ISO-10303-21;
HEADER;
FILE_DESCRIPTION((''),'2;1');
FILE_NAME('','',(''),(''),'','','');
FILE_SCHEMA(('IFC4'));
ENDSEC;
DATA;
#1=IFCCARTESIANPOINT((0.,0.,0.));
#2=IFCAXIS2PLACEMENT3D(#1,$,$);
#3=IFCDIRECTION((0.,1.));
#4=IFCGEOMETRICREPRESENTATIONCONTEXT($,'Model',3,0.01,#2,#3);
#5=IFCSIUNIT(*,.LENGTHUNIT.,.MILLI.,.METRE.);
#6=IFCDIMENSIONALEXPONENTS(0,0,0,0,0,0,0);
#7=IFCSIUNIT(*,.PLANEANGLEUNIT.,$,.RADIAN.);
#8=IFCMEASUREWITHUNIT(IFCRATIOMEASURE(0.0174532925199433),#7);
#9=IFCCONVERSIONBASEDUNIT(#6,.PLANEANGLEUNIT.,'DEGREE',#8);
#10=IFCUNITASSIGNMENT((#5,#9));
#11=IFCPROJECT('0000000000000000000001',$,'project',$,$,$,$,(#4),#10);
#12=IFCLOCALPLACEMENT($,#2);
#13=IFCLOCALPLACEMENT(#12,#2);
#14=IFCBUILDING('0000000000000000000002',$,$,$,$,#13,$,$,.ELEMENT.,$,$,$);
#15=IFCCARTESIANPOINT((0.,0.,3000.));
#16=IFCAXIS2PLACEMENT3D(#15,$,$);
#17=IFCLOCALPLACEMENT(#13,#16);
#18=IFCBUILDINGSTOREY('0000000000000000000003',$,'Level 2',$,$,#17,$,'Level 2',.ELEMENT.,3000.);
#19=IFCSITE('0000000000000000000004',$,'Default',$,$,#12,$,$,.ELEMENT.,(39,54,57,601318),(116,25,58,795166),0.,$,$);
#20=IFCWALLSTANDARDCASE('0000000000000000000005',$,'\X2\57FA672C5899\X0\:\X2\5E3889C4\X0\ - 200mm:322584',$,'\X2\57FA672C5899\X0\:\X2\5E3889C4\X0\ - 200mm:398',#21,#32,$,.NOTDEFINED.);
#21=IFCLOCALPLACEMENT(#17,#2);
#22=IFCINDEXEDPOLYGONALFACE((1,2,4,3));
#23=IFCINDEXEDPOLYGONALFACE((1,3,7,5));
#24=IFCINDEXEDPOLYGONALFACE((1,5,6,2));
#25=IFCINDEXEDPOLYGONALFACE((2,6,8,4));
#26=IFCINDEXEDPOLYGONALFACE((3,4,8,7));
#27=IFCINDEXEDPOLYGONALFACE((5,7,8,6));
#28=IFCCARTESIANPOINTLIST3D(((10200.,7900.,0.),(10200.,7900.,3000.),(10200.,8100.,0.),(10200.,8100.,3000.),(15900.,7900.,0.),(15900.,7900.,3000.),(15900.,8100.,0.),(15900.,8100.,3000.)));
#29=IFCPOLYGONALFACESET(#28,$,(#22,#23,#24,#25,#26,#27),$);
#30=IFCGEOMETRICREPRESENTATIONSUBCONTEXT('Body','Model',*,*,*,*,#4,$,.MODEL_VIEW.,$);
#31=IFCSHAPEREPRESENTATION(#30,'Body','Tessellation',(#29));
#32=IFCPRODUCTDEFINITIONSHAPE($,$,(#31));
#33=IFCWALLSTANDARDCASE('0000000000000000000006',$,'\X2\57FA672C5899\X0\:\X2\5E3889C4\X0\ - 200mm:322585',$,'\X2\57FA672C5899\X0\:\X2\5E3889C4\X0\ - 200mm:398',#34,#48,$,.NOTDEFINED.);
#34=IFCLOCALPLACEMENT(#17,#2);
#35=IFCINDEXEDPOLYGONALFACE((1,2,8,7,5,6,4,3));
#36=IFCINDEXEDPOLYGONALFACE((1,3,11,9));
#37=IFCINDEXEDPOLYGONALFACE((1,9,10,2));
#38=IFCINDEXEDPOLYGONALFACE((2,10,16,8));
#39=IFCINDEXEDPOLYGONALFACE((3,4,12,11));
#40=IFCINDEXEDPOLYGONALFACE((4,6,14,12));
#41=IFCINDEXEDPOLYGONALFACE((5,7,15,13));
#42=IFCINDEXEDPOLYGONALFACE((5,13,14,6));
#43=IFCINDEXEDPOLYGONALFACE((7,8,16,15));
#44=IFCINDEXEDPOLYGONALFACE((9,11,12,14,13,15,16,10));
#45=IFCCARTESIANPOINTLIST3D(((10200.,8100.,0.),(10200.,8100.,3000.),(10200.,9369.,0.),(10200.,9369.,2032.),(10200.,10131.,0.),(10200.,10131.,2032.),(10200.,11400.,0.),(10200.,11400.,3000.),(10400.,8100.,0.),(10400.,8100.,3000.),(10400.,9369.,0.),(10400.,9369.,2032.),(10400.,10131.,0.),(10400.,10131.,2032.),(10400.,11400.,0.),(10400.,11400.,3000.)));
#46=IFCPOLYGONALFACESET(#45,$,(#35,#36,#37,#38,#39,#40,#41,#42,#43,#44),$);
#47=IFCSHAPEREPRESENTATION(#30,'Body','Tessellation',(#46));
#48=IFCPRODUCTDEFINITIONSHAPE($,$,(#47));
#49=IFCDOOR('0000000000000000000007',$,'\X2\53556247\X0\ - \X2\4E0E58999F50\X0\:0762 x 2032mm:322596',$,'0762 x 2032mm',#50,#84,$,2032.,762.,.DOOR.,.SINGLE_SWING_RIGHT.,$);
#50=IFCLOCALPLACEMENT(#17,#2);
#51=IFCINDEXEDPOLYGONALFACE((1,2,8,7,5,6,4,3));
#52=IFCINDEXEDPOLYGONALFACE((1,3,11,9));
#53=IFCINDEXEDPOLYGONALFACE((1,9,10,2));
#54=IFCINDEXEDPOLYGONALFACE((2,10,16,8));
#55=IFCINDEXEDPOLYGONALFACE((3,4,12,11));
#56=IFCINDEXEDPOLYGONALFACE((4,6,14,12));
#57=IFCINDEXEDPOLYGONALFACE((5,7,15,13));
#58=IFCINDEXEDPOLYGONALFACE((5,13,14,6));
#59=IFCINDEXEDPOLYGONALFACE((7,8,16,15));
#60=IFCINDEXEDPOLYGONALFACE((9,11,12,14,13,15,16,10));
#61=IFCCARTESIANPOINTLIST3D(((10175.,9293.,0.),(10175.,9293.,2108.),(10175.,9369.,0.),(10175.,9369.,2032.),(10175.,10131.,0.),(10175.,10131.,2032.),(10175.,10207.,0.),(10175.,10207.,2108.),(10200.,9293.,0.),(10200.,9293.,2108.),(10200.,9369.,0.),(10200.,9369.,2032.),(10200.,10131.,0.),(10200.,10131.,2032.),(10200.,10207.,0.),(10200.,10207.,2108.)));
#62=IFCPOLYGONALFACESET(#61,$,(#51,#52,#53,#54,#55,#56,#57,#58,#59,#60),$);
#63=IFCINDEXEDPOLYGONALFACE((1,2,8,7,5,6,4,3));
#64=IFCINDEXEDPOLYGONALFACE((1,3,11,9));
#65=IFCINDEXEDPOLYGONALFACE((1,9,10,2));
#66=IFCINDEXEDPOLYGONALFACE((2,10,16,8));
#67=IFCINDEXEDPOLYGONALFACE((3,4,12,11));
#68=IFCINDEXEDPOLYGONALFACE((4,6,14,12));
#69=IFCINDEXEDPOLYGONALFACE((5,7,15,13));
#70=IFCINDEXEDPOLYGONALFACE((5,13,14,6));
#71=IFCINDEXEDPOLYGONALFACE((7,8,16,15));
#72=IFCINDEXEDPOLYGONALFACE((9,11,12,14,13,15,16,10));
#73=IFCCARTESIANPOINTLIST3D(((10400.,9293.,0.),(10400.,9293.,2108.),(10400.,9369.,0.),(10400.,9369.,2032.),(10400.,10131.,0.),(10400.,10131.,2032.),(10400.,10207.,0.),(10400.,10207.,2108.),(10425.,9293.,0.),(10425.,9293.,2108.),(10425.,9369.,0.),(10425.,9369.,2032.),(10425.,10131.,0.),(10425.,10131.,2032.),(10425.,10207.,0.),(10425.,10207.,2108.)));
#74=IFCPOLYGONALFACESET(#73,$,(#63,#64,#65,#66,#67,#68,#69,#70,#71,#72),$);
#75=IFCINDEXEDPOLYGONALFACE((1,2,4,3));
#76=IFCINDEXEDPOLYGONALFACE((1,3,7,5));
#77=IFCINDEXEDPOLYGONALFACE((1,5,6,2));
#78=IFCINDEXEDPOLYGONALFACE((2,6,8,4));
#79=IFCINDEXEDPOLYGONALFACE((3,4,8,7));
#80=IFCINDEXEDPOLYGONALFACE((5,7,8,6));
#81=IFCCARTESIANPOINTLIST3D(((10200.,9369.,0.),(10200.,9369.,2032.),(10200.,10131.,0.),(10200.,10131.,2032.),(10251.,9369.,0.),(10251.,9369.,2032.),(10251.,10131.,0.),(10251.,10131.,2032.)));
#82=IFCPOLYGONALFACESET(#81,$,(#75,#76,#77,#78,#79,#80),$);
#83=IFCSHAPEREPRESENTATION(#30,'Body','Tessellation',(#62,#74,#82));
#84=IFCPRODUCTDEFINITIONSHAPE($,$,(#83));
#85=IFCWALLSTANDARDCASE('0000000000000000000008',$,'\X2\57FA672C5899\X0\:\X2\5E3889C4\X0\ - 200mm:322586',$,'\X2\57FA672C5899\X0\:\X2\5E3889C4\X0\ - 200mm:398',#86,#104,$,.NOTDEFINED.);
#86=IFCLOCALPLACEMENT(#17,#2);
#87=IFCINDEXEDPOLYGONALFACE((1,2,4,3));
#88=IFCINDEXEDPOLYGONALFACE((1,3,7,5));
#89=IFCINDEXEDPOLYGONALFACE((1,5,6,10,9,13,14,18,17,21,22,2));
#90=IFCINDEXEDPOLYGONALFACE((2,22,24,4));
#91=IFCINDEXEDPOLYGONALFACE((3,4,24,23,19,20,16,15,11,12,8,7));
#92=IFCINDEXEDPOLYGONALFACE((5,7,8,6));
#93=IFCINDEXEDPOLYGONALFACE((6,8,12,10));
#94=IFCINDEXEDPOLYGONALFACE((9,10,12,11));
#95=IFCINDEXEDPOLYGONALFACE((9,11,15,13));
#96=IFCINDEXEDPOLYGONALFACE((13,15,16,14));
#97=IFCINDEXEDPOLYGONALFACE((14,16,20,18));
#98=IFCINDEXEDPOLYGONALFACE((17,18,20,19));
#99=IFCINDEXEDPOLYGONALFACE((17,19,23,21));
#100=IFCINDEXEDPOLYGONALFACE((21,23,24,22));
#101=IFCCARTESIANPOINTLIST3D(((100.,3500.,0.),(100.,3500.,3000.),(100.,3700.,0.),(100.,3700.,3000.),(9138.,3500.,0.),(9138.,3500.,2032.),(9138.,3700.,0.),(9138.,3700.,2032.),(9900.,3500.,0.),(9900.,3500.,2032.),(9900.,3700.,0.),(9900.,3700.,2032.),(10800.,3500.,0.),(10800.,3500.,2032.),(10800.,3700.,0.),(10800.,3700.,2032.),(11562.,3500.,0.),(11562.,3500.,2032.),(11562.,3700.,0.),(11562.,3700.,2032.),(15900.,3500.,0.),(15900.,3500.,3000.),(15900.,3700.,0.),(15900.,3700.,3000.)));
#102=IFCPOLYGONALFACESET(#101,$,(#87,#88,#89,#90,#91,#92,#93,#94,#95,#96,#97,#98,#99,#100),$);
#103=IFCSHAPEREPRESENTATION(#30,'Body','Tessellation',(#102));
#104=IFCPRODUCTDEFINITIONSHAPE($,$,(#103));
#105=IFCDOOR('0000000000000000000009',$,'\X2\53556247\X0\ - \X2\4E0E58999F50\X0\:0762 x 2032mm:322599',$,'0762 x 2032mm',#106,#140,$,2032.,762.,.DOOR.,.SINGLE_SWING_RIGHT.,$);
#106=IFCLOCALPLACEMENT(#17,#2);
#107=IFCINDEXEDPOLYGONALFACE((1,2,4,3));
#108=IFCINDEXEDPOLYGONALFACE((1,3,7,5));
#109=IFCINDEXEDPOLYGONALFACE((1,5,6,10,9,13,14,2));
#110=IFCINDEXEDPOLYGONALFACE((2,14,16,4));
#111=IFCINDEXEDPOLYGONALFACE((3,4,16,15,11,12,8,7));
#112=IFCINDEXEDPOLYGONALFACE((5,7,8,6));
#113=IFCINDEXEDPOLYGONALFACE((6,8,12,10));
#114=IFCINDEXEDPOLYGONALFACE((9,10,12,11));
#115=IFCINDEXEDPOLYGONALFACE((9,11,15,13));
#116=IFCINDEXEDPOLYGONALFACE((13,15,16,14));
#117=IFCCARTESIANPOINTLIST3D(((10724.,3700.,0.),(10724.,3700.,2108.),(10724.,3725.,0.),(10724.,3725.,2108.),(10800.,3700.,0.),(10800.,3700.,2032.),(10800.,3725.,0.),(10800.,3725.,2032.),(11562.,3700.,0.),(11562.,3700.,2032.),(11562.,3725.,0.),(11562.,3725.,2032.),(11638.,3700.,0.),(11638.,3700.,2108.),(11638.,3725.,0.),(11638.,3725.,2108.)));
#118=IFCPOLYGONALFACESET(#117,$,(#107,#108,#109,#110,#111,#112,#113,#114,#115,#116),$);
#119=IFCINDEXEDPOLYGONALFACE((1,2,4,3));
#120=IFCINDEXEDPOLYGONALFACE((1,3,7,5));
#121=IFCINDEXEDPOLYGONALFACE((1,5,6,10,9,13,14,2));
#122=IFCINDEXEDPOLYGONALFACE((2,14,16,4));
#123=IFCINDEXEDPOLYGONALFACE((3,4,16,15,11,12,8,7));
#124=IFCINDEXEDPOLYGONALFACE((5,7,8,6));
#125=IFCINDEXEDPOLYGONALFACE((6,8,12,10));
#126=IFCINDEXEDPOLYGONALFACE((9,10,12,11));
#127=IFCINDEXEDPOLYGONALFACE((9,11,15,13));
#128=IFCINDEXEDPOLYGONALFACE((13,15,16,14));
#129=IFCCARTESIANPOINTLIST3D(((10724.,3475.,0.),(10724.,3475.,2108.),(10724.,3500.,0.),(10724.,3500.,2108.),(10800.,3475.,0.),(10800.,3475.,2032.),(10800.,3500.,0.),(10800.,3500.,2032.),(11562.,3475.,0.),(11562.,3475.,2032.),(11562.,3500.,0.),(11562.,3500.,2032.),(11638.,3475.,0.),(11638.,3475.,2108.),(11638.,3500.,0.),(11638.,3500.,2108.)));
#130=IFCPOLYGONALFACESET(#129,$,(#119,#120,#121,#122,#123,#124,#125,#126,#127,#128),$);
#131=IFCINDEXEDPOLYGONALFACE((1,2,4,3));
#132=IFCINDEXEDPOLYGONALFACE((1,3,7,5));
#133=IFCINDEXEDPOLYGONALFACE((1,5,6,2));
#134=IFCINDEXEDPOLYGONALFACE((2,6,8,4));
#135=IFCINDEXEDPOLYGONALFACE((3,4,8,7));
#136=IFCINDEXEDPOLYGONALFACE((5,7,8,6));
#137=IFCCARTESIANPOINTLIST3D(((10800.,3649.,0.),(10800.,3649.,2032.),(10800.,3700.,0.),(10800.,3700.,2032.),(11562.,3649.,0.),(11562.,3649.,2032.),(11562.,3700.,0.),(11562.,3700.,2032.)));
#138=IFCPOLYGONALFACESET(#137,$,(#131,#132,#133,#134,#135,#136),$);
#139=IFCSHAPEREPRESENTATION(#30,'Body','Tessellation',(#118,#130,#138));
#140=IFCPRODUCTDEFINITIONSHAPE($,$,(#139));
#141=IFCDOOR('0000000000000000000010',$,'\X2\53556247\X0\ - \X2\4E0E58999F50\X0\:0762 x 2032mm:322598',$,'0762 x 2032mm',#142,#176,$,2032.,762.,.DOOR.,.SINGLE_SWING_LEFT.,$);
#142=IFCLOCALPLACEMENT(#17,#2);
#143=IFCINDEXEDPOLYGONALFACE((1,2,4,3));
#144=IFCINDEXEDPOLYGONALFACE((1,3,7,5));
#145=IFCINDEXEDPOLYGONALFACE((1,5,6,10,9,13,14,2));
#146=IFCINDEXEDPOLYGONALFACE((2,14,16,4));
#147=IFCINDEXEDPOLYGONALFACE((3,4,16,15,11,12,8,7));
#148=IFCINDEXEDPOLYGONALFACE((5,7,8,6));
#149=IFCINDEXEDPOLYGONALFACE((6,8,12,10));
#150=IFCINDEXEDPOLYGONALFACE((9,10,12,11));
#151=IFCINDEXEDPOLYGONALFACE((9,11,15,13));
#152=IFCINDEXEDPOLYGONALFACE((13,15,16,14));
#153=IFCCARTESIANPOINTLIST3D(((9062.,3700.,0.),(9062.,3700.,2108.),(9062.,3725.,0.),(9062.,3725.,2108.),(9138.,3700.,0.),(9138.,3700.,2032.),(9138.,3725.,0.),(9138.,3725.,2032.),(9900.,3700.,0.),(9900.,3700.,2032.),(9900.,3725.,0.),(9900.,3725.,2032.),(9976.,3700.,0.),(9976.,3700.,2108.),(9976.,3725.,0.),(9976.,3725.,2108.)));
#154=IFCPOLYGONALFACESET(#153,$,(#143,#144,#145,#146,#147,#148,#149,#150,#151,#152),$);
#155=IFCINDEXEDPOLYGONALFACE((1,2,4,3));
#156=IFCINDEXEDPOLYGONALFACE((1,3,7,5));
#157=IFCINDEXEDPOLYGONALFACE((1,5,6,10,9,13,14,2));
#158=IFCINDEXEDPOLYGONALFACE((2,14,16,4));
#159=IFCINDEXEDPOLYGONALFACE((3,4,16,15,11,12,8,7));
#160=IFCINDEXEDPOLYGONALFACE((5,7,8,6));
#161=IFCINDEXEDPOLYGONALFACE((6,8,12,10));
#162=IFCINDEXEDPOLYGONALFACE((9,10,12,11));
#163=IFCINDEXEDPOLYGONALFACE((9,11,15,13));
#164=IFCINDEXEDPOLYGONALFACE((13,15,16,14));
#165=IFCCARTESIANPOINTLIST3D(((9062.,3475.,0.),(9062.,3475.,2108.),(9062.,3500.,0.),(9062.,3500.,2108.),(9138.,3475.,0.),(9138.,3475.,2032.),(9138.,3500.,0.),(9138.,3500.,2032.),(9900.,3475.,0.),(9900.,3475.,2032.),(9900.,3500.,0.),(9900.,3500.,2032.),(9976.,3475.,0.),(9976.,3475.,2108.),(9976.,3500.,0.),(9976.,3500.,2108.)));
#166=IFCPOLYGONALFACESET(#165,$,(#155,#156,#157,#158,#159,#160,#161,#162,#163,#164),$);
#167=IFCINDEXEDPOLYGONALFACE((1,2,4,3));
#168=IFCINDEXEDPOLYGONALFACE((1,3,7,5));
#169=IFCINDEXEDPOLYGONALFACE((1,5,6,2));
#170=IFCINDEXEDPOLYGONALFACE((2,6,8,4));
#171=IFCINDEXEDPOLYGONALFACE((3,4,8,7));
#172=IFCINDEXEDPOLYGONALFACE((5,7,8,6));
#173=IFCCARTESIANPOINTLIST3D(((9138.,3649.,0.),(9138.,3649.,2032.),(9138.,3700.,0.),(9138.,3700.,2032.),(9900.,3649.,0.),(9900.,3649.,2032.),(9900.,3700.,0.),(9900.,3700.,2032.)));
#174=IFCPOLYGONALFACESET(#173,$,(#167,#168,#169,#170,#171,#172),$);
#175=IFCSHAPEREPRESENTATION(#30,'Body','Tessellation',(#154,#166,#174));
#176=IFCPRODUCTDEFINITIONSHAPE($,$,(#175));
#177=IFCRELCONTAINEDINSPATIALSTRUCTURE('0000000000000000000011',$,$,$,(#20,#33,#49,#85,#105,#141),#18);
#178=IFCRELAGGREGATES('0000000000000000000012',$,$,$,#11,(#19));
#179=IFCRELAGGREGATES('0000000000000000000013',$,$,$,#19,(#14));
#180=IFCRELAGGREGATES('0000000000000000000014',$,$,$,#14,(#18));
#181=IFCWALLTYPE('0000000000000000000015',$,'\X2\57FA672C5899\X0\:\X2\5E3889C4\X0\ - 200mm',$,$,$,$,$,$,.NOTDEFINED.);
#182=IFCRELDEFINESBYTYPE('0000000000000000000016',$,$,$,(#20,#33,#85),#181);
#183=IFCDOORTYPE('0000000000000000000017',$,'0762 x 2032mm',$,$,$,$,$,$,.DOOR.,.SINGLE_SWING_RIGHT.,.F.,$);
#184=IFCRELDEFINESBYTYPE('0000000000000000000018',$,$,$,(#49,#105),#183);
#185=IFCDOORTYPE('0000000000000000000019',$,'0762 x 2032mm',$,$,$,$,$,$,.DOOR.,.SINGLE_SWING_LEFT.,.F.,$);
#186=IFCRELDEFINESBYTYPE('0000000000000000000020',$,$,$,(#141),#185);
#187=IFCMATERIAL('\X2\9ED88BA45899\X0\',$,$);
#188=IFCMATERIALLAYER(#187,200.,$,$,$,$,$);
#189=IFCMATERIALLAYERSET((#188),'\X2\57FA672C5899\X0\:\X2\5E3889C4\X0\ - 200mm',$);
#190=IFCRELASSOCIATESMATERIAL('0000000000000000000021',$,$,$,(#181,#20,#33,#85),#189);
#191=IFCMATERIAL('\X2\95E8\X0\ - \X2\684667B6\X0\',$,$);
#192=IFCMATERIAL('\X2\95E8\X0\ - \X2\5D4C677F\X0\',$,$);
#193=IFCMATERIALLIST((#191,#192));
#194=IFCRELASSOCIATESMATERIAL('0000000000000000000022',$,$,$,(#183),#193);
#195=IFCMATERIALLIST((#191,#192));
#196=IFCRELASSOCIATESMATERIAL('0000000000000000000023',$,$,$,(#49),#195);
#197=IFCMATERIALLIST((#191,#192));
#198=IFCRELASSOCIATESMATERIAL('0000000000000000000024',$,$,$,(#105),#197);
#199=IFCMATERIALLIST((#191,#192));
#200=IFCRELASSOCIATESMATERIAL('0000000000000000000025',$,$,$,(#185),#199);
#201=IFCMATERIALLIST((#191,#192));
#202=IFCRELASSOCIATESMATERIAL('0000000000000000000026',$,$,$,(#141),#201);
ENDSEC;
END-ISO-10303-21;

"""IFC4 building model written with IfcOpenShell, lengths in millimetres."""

from ifc_helpers import new_model, entity, si_unit, converted_unit, direction, frame, frame_2d, origin, origin_2d_with_axis, place, context, subcontext, project, spatial, polyline, rectangle, outline, extrude, source, transform, mapped, material, material_list, layer, layer_set, layer_usage, type_object, type_shapes, element, fill, save


model = new_model("IFC4")

# Units and contexts
model_context = context("Model", 3, precision=0.01, world=origin(), true_north=direction((0.0, 1.0)))
body_context = subcontext(model_context, "Body", "Model", "MODEL_VIEW")
ifc_project = project(units=[si_unit("LENGTHUNIT", "METRE", prefix="MILLI"), converted_unit("PLANEANGLEUNIT", "DEGREE", entity("IfcRatioMeasure", 0.0174532925199433), si_unit("PLANEANGLEUNIT", "RADIAN"), dimensions=[0, 0, 0, 0, 0, 0, 0])], contexts=[model_context])

# Site, building, storey
site_placement = place(None, origin())
site = spatial("IfcSite", under=ifc_project, at=site_placement, Name="Default", CompositionType="ELEMENT", RefLatitude=(39, 54, 57, 601318), RefLongitude=(116, 25, 58, 795166), RefElevation=0.0)
building_placement = place(site_placement, origin())
building = spatial("IfcBuilding", under=site, at=building_placement, CompositionType="ELEMENT")
storey_placement = place(building_placement, frame((0.0, 0.0, 3000.0)))
storey = spatial("IfcBuildingStorey", under=building, at=storey_placement, Name="Level 2", LongName="Level 2", CompositionType="ELEMENT", Elevation=3000.0)

# Wall
ifc_material_1 = material(Name="默认墙")
ifc_layer_1 = layer(ifc_material_1, 200.0)
ifc_layer_set_1 = layer_set([ifc_layer_1], Name="基本墙:常规 - 200mm")
ifc_layer_usage_1 = layer_usage(ifc_layer_set_1, "AXIS2", "NEGATIVE", 100.0)
wall_type = type_object("IfcWallType", Name="基本墙:常规 - 200mm", PredefinedType="NOTDEFINED", material=ifc_layer_set_1)
wall_1_placement = place(storey_placement, frame((10200.0, 8000.0, 0.0)))
element("IfcWallStandardCase", 1, at=wall_1_placement, inside=storey, type_object=wall_type, material=ifc_layer_usage_1, Name="基本墙:常规 - 200mm:322584", ObjectType="基本墙:常规 - 200mm:398", PredefinedType="NOTDEFINED", context=body_context, shape_type="SweptSolid", body=[
    extrude(rectangle(XDim=5700.0, YDim=200.0, at=frame_2d((2850.0, 0.0), x_axis=(-1.0, 0.0))), origin(), (0.0, 0.0, 1.0), 3000.0),
])

# Wall, opening, door
ifc_layer_usage_2 = layer_usage(ifc_layer_set_1, "AXIS2", "NEGATIVE", 100.0)
wall_2_placement = place(storey_placement, frame((10300.0, 11400.0, 0.0), z_axis=(0.0, 0.0, 1.0), x_axis=(0.0, -1.0, 0.0)))
wall_2 = element("IfcWallStandardCase", 2, at=wall_2_placement, inside=storey, type_object=wall_type, material=ifc_layer_usage_2, Name="基本墙:常规 - 200mm:322585", ObjectType="基本墙:常规 - 200mm:398", PredefinedType="NOTDEFINED", context=body_context, shape_type="SweptSolid", body=[
    extrude(rectangle(XDim=3300.0, YDim=200.0, at=frame_2d((1650.0, 0.0), x_axis=(-1.0, 0.0))), origin(), (0.0, 0.0, 1.0), 3000.0),
])
opening_1_placement = place(wall_2_placement, frame((2031.0, 100.0, 0.0)))
opening_1 = element("IfcOpeningElement", 3, at=opening_1_placement, cuts=wall_2, ObjectType="Opening", PredefinedType="OPENING", context=body_context, shape_type="SweptSolid", body=[
    extrude(rectangle(XDim=762.0, YDim=2032.0, at=frame_2d((1016.0, 381.0), x_axis=(0.0, 1.0))), frame((0.0, 0.0, 0.0), z_axis=(0.0, -1.0, 0.0), x_axis=(0.0, 0.0, 1.0)), (0.0, 0.0, 1.0), 200.0),
])
ifc_material_2 = material(Name="门 - 框架")
ifc_material_3 = material(Name="门 - 嵌板")
ifc_material_list_1 = material_list([ifc_material_2, ifc_material_3])
ifc_material_list_2 = material_list([ifc_material_2, ifc_material_3])
door_type_1 = type_object("IfcDoorType", Name="0762 x 2032mm", OperationType="SINGLE_SWING_RIGHT", ParameterTakesPrecedence=False, PredefinedType="DOOR", material=ifc_material_list_2)
shared_shape_1 = source(origin(), body_context, "Body", "SweptSolid", [
    extrude(outline(polyline([(-457.0, -1073.0), (457.0, -1073.0), (457.0, 1035.0), (381.0, 1035.0), (381.0, -997.0), (-381.0, -997.0), (-381.0, 1035.0), (-457.0, 1035.0), (-457.0, -1073.0)])), frame((381.0, 200.0, 1035.0), z_axis=(0.0, 1.0, 0.0), x_axis=(1.0, 0.0, 0.0)), (0.0, 0.0, 1.0), 25.0),
    extrude(outline(polyline([(-1073.0, -457.0), (1035.0, -457.0), (1035.0, -381.0), (-997.0, -381.0), (-997.0, 381.0), (1035.0, 381.0), (1035.0, 457.0), (-1073.0, 457.0), (-1073.0, -457.0)])), frame((381.0, -25.0, 1035.0), z_axis=(0.0, 1.0, 0.0), x_axis=(0.0, 0.0, -1.0)), (0.0, 0.0, 1.0), 25.0),
    extrude(rectangle(XDim=51.0, YDim=762.0, at=origin_2d_with_axis()), frame((381.0, 174.5, 0.0), z_axis=(0.0, 0.0, 1.0), x_axis=(0.0, 1.0, 0.0)), (0.0, 0.0, 1.0), 2032.0),
])
type_shapes(door_type_1, [shared_shape_1])
door_1_placement = place(opening_1_placement, frame((0.0, 0.0, 0.0), z_axis=(0.0, 0.0, 1.0), x_axis=(-1.0, 0.0, 0.0)))
door_1 = element("IfcDoor", 4, at=door_1_placement, inside=storey, type_object=door_type_1, material=ifc_material_list_1, Name="单扇 - 与墙齐:0762 x 2032mm:322596", ObjectType="0762 x 2032mm", OperationType="SINGLE_SWING_RIGHT", OverallHeight=2032.0, OverallWidth=762.0, PredefinedType="DOOR", context=body_context, shape_type="MappedRepresentation", body=[
    mapped(shared_shape_1, transform((0.0, 0.0, 0.0), scale=1.0)),
])
fill(opening_1, door_1)

# Wall, openings, doors
ifc_layer_usage_3 = layer_usage(ifc_layer_set_1, "AXIS2", "NEGATIVE", 100.0)
wall_3_placement = place(storey_placement, frame((15900.0, 3600.0, 0.0), z_axis=(0.0, 0.0, 1.0), x_axis=(-1.0, 0.0, 0.0)))
wall_3 = element("IfcWallStandardCase", 5, at=wall_3_placement, inside=storey, type_object=wall_type, material=ifc_layer_usage_3, Name="基本墙:常规 - 200mm:322586", ObjectType="基本墙:常规 - 200mm:398", PredefinedType="NOTDEFINED", context=body_context, shape_type="SweptSolid", body=[
    extrude(rectangle(XDim=15800.0, YDim=200.0, at=frame_2d((7900.0, 0.0), x_axis=(-1.0, 0.0))), origin(), (0.0, 0.0, 1.0), 3000.0),
])
opening_2_placement = place(wall_3_placement, frame((6762.0, 100.0, 0.0)))
opening_2 = element("IfcOpeningElement", 6, at=opening_2_placement, cuts=wall_3, ObjectType="Opening", PredefinedType="OPENING", context=body_context, shape_type="SweptSolid", body=[
    extrude(rectangle(XDim=762.0, YDim=2032.0, at=frame_2d((1016.0, 381.0), x_axis=(0.0, -1.0))), frame((0.0, 0.0, 0.0), z_axis=(0.0, -1.0, 0.0), x_axis=(0.0, 0.0, 1.0)), (0.0, 0.0, 1.0), 200.0),
])
opening_3_placement = place(wall_3_placement, frame((5100.0, 100.0, 0.0)))
opening_3 = element("IfcOpeningElement", 7, at=opening_3_placement, cuts=wall_3, ObjectType="Opening", PredefinedType="OPENING", context=body_context, shape_type="SweptSolid", body=[
    extrude(rectangle(XDim=762.0, YDim=2032.0, at=frame_2d((1016.0, 381.0), x_axis=(0.0, 1.0))), frame((0.0, 0.0, 0.0), z_axis=(0.0, -1.0, 0.0), x_axis=(0.0, 0.0, 1.0)), (0.0, 0.0, 1.0), 200.0),
])
ifc_material_list_3 = material_list([ifc_material_2, ifc_material_3])
door_2_placement = place(opening_3_placement, frame((0.0, 0.0, 0.0), z_axis=(0.0, 0.0, 1.0), x_axis=(-1.0, 0.0, 0.0)))
door_2 = element("IfcDoor", 8, at=door_2_placement, inside=storey, type_object=door_type_1, material=ifc_material_list_3, Name="单扇 - 与墙齐:0762 x 2032mm:322599", ObjectType="0762 x 2032mm", OperationType="SINGLE_SWING_RIGHT", OverallHeight=2032.0, OverallWidth=762.0, PredefinedType="DOOR", context=body_context, shape_type="MappedRepresentation", body=[
    mapped(shared_shape_1, transform((0.0, 0.0, 0.0), scale=1.0)),
])
fill(opening_3, door_2)
ifc_material_list_4 = material_list([ifc_material_2, ifc_material_3])
ifc_material_list_5 = material_list([ifc_material_2, ifc_material_3])
door_type_2 = type_object("IfcDoorType", Name="0762 x 2032mm", OperationType="SINGLE_SWING_LEFT", ParameterTakesPrecedence=False, PredefinedType="DOOR", material=ifc_material_list_5)
shared_shape_2 = source(origin(), body_context, "Body", "SweptSolid", [
    extrude(outline(polyline([(-457.0, -1073.0), (457.0, -1073.0), (457.0, 1035.0), (381.0, 1035.0), (381.0, -997.0), (-381.0, -997.0), (-381.0, 1035.0), (-457.0, 1035.0), (-457.0, -1073.0)])), frame((381.0, 225.0, 1035.0), z_axis=(0.0, -1.0, 0.0), x_axis=(-1.0, 0.0, 0.0)), (0.0, 0.0, 1.0), 25.0),
    extrude(outline(polyline([(-1073.0, -457.0), (1035.0, -457.0), (1035.0, -381.0), (-997.0, -381.0), (-997.0, 381.0), (1035.0, 381.0), (1035.0, 457.0), (-1073.0, 457.0), (-1073.0, -457.0)])), frame((381.0, 0.0, 1035.0), z_axis=(0.0, -1.0, 0.0), x_axis=(0.0, 0.0, -1.0)), (0.0, 0.0, 1.0), 25.0),
    extrude(rectangle(XDim=762.0, YDim=51.0, at=origin_2d_with_axis()), frame((381.0, 174.5, 0.0)), (0.0, 0.0, 1.0), 2032.0),
])
type_shapes(door_type_2, [shared_shape_2])
door_3_placement = place(opening_2_placement, frame((0.0, 0.0, 0.0), z_axis=(0.0, 0.0, 1.0), x_axis=(-1.0, 0.0, 0.0)))
door_3 = element("IfcDoor", 9, at=door_3_placement, inside=storey, type_object=door_type_2, material=ifc_material_list_4, Name="单扇 - 与墙齐:0762 x 2032mm:322598", ObjectType="0762 x 2032mm", OperationType="SINGLE_SWING_LEFT", OverallHeight=2032.0, OverallWidth=762.0, PredefinedType="DOOR", context=body_context, shape_type="MappedRepresentation", body=[
    mapped(shared_shape_2, transform((0.0, 0.0, 0.0), scale=1.0)),
])
fill(opening_2, door_3)

save(model, "model.ifc")
